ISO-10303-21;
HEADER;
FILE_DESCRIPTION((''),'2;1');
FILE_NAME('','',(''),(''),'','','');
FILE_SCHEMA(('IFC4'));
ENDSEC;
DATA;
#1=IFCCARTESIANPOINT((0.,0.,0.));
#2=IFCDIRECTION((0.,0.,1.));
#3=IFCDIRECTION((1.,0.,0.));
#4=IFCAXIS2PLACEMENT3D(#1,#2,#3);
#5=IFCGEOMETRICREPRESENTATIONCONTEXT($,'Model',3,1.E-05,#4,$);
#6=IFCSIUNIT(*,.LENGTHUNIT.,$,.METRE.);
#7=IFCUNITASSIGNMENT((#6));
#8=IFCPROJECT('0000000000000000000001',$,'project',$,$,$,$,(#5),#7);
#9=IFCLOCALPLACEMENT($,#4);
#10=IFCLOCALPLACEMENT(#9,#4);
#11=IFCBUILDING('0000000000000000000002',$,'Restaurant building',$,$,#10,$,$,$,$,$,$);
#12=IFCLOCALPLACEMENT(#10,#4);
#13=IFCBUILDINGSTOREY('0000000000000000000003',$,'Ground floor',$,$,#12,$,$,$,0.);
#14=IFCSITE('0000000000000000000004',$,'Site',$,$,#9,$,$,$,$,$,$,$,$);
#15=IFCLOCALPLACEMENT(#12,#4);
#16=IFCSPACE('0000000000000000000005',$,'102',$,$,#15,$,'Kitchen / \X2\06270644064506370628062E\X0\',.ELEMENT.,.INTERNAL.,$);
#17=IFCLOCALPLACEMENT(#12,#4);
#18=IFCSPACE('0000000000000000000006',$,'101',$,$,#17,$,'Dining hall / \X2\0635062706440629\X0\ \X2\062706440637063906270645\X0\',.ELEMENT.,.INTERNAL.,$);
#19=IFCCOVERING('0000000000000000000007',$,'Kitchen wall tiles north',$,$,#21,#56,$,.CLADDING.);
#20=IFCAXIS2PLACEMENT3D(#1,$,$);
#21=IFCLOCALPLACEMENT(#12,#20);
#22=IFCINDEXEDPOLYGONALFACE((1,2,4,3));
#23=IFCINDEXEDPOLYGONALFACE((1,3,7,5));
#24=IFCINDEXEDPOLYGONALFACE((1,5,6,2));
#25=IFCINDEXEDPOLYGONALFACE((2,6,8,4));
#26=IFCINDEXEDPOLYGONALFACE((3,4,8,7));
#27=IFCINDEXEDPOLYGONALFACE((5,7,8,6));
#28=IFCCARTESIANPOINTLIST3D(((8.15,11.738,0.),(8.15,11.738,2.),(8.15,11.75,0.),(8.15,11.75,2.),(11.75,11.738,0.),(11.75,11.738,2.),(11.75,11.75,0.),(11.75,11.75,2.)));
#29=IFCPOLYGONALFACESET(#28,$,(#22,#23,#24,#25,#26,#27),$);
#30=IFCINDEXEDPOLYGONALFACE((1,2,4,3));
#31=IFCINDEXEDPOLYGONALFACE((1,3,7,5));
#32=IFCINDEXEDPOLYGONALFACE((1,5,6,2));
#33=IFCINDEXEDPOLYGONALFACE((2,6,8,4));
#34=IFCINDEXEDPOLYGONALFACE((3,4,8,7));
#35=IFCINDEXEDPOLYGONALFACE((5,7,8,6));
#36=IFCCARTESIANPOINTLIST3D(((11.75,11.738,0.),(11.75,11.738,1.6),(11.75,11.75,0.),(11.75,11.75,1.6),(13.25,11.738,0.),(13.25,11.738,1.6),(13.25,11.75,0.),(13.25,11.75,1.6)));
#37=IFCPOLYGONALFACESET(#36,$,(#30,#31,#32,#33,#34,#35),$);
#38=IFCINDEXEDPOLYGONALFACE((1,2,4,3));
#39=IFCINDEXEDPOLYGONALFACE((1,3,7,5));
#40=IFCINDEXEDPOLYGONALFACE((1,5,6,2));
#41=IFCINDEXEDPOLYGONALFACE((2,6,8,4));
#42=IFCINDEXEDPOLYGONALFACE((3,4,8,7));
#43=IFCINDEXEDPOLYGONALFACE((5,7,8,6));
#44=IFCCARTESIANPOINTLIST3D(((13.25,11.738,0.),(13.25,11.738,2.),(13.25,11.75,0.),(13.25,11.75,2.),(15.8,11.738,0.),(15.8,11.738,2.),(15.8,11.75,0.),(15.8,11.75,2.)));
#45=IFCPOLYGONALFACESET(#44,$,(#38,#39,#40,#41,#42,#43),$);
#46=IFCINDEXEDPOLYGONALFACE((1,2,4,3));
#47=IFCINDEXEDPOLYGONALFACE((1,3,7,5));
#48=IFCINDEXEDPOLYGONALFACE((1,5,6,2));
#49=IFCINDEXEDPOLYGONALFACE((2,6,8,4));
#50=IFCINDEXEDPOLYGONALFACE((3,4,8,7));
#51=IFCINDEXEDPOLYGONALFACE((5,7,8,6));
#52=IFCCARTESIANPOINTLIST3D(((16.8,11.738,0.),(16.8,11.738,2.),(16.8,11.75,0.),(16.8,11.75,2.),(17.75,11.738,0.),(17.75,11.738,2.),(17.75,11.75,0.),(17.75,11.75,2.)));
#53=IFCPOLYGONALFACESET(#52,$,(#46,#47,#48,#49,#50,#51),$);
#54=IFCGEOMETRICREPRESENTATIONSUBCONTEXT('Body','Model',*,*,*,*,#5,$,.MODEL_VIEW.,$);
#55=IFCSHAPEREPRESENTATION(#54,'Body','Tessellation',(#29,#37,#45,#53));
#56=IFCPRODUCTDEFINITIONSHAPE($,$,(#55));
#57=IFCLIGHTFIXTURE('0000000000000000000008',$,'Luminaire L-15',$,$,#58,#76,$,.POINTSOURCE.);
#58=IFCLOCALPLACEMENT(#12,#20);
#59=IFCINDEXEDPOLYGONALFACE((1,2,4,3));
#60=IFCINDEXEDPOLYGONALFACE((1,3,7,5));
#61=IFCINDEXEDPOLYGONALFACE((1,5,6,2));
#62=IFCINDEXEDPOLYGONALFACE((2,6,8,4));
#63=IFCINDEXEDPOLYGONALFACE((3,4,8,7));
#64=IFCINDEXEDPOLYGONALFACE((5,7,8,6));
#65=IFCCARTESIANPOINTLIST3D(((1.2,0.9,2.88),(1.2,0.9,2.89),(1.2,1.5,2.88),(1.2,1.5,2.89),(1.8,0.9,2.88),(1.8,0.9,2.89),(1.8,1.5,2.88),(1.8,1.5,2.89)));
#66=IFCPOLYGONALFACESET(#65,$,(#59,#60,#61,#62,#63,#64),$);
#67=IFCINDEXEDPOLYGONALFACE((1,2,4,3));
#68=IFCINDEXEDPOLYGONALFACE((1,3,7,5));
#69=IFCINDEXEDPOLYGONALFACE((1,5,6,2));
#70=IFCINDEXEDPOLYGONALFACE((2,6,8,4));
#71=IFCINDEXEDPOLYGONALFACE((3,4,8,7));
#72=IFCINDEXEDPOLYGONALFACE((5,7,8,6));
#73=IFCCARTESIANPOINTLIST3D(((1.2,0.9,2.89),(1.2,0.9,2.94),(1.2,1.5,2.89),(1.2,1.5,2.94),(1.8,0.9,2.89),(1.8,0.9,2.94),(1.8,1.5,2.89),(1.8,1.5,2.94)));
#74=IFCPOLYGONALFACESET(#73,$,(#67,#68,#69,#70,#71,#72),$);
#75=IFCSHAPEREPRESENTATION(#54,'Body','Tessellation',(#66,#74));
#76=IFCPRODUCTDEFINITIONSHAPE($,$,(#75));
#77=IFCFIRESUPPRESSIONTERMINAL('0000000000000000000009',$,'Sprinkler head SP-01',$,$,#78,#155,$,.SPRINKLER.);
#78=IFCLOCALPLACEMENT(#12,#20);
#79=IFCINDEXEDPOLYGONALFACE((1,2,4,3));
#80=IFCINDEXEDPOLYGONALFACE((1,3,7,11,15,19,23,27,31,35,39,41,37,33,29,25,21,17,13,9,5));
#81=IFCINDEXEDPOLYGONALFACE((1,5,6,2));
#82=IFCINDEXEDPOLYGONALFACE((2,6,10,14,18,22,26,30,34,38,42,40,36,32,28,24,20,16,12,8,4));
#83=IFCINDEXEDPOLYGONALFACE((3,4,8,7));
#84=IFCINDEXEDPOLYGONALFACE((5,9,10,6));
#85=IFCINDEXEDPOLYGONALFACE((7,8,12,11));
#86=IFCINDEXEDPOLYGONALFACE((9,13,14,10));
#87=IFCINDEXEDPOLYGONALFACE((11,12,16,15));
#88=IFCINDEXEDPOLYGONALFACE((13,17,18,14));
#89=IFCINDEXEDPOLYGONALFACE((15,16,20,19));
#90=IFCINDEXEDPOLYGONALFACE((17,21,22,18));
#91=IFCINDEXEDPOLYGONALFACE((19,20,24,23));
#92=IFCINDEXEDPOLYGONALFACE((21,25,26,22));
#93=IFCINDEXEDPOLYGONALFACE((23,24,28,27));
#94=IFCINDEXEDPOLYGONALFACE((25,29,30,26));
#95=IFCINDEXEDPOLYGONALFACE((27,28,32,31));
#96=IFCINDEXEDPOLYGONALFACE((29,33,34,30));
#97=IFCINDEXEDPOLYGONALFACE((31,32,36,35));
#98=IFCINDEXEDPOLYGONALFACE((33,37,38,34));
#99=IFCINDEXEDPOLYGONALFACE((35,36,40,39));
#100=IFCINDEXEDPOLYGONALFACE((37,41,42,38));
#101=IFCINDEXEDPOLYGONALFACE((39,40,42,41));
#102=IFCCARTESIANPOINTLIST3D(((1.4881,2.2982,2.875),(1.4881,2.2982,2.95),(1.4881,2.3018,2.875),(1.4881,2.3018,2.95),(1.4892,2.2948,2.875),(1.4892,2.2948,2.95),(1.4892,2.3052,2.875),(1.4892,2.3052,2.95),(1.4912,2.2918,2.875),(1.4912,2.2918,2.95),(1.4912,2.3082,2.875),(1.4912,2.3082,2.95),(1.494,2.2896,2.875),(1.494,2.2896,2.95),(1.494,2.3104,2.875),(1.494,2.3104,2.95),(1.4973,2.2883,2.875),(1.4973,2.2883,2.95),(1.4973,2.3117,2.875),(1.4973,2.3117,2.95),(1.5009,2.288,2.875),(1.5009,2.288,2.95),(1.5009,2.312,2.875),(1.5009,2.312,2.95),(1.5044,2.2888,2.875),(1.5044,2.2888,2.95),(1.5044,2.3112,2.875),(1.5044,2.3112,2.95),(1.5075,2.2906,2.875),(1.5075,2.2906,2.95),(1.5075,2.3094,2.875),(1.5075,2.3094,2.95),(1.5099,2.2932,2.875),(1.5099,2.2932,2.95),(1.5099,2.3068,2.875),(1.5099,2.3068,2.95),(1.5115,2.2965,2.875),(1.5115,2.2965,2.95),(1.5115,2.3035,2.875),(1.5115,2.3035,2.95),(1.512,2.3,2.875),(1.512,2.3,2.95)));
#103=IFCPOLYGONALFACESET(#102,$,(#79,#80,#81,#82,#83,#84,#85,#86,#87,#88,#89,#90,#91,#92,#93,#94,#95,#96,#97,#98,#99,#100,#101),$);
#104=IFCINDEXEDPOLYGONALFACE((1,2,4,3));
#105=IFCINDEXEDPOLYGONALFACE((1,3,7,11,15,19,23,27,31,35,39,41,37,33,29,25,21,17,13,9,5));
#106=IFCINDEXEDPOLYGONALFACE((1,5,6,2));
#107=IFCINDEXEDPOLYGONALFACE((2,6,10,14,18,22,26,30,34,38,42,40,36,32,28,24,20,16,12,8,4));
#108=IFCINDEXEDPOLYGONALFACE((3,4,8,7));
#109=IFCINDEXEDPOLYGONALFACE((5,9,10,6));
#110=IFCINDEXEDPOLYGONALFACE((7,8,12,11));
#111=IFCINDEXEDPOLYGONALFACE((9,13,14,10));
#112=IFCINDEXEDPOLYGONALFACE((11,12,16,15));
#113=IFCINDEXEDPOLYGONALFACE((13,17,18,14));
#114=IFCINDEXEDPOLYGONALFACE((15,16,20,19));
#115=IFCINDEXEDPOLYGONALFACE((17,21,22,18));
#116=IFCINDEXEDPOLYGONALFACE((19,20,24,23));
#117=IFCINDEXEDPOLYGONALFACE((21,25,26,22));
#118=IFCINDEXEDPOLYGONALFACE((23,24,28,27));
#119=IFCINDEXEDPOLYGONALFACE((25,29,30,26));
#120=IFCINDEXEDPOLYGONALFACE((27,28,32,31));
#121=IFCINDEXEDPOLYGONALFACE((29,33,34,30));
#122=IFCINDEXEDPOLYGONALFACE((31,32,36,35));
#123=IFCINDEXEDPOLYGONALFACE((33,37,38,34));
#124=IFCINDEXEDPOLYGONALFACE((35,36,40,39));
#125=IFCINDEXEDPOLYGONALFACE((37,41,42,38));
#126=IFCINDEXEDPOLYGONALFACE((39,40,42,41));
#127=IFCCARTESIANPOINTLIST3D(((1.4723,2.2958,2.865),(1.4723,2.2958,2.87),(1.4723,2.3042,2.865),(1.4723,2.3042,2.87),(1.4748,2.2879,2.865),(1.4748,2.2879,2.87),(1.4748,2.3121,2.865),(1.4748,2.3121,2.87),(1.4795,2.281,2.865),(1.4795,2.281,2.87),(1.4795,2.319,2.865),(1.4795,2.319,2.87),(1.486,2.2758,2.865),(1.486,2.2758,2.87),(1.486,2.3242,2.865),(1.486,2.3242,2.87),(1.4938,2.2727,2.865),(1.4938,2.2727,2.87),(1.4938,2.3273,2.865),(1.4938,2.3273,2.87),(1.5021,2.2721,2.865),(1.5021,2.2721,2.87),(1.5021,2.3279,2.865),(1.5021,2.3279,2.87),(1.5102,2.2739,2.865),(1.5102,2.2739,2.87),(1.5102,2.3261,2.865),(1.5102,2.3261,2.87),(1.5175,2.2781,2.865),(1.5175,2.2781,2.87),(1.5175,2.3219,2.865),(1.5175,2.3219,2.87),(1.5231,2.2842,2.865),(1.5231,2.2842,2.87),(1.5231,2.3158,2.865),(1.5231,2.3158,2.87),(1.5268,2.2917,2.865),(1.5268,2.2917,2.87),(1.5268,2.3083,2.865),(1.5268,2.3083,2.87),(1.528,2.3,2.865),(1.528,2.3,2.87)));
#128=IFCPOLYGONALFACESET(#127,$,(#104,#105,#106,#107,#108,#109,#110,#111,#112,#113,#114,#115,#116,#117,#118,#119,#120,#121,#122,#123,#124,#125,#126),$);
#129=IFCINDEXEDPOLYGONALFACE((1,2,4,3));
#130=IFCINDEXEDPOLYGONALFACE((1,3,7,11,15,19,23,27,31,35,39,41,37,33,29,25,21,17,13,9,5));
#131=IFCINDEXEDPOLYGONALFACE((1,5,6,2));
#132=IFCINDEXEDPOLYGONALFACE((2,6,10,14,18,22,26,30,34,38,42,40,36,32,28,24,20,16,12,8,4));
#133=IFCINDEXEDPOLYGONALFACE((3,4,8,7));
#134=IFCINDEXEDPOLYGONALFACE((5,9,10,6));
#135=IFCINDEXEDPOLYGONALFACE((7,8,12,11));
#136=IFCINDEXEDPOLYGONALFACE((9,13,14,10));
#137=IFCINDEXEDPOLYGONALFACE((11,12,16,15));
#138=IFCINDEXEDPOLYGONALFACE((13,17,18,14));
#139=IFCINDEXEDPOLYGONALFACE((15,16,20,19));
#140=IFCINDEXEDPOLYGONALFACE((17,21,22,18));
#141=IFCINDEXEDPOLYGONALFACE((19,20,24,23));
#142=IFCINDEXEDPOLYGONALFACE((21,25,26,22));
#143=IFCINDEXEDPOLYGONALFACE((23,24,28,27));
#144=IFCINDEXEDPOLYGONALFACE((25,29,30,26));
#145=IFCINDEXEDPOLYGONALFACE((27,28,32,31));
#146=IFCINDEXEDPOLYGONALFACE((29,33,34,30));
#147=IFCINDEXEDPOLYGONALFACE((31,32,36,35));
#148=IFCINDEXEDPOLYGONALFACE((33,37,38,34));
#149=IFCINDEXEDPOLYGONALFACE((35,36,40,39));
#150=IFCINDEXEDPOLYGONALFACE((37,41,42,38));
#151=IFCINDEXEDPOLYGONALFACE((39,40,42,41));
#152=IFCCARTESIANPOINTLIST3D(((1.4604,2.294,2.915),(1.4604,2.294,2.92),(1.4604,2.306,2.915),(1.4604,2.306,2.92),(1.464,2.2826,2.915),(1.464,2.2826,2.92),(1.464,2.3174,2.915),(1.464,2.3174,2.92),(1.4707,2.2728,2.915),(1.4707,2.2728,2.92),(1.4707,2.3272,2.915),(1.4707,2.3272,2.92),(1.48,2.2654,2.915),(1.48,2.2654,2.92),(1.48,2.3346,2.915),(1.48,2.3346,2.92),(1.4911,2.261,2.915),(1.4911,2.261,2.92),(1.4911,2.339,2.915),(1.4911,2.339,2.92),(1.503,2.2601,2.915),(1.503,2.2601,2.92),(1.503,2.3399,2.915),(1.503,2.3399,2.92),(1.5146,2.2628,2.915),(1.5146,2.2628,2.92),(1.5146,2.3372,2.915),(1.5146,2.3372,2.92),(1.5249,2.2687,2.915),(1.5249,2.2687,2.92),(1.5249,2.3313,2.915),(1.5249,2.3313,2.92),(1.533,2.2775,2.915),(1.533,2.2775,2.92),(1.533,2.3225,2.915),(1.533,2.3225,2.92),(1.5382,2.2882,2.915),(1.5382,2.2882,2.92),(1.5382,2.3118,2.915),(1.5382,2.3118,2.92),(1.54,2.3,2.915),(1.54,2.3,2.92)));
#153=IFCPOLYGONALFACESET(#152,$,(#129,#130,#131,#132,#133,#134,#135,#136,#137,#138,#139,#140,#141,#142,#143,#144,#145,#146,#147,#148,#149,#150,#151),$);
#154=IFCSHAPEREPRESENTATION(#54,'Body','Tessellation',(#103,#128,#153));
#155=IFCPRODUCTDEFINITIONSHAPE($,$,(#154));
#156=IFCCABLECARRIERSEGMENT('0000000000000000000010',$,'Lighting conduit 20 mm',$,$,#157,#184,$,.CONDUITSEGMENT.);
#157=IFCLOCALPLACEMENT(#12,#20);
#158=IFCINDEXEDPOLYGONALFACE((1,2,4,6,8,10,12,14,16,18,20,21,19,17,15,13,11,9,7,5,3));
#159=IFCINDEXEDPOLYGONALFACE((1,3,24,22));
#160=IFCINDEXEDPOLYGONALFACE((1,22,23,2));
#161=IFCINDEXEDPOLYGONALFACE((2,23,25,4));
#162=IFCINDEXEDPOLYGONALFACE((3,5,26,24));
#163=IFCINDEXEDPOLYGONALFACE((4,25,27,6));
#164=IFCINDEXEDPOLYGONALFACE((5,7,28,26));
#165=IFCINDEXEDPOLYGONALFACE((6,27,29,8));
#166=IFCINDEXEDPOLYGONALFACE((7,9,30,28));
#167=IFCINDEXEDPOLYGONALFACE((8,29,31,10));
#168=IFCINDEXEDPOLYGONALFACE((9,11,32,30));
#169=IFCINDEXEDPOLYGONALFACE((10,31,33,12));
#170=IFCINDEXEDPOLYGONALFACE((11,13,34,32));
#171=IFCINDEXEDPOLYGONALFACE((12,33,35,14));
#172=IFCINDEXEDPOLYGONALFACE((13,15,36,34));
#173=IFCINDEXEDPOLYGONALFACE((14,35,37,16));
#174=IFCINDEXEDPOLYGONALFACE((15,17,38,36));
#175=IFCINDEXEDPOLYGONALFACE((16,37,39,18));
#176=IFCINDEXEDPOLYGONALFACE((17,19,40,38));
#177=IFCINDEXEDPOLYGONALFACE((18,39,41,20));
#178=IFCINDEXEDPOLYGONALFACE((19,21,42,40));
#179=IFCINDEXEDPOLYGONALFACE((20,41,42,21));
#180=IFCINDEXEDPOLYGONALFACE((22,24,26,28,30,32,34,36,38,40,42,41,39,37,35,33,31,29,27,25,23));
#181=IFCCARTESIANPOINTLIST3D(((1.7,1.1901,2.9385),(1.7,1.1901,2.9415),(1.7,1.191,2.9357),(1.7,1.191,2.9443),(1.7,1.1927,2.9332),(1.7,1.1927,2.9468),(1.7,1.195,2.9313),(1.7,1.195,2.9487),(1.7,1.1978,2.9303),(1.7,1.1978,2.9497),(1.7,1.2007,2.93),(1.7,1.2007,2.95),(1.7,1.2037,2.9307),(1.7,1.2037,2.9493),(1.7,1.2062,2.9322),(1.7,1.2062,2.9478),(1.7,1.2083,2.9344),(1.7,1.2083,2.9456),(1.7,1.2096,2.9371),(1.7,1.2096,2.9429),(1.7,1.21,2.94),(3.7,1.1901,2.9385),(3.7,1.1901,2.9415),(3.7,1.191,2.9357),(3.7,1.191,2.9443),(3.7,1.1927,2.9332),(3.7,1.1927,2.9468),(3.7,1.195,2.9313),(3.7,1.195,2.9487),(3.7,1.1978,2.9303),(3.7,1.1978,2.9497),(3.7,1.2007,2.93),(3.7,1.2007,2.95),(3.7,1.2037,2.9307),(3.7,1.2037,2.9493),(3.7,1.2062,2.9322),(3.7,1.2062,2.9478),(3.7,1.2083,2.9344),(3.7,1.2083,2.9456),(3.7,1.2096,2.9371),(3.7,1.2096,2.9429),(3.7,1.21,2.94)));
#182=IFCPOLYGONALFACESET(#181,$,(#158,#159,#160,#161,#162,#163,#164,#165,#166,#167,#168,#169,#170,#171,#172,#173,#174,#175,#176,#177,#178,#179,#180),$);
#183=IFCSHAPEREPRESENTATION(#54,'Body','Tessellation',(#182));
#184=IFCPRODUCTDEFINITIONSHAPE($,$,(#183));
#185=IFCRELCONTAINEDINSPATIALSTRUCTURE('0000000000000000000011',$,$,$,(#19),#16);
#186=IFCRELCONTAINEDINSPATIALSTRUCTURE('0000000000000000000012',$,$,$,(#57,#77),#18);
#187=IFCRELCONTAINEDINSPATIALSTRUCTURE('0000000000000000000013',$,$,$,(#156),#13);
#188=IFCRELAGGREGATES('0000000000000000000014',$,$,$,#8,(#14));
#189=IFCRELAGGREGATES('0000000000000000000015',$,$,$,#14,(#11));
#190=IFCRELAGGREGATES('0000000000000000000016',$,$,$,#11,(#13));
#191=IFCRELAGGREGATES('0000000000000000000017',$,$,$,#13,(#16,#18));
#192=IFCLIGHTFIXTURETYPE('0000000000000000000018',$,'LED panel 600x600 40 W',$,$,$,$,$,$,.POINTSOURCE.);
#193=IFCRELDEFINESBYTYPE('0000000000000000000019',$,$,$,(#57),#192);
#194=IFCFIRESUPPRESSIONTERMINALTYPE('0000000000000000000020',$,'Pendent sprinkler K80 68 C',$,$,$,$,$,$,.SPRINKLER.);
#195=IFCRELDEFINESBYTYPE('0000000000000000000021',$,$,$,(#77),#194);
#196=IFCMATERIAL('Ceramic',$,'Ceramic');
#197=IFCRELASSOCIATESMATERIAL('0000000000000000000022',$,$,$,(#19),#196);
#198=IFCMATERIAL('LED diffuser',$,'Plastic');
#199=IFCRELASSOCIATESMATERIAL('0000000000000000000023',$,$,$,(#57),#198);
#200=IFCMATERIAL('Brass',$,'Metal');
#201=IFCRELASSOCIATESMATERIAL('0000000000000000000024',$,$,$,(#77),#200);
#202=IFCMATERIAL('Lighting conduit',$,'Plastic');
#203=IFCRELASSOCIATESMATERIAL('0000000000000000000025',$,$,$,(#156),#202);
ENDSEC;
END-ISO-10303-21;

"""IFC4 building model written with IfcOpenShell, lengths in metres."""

from ifc_helpers import new_model, si_unit, frame, origin, origin_with_axes, origin_2d, place, context, subcontext, project, spatial, rectangle, circle, extrude, source, transform, mapped, material, type_object, type_shapes, element, save


model = new_model("IFC4")

# Units and contexts
model_context = context("Model", 3, precision=1e-05, world=origin_with_axes())
body_context = subcontext(model_context, "Body", "Model", "MODEL_VIEW")
ifc_project = project(units=[si_unit("LENGTHUNIT", "METRE")], contexts=[model_context])

# Site, building, storey
site_placement = place(None, origin_with_axes())
site = spatial("IfcSite", under=ifc_project, at=site_placement, Name="Site")
building_placement = place(site_placement, origin_with_axes())
building = spatial("IfcBuilding", under=site, at=building_placement, Name="Restaurant building")
storey_placement = place(building_placement, origin_with_axes())
storey = spatial("IfcBuildingStorey", under=building, at=storey_placement, Name="Ground floor", Elevation=0.0)

# Shared definitions
space_1_placement = place(storey_placement, origin_with_axes())
space_1 = spatial("IfcSpace", under=storey, at=space_1_placement, Name="102", LongName="Kitchen / المطبخ", CompositionType="ELEMENT", PredefinedType="INTERNAL")

# Covering
ifc_material_1 = material(Name="Ceramic", Category="Ceramic")
covering_1_placement = place(storey_placement, origin())
element("IfcCovering", 1, at=covering_1_placement, inside=space_1, material=ifc_material_1, Name="Kitchen wall tiles north", PredefinedType="CLADDING", context=body_context, shape_type="SweptSolid", body=[
    extrude(rectangle(XDim=3.6, YDim=0.012, at=origin_2d()), frame((9.95, 11.744, 0.0)), (0.0, 0.0, 1.0), 2.0),
    extrude(rectangle(XDim=1.5, YDim=0.012, at=origin_2d()), frame((12.5, 11.744, 0.0)), (0.0, 0.0, 1.0), 1.6),
    extrude(rectangle(XDim=2.55, YDim=0.012, at=origin_2d()), frame((14.525, 11.744, 0.0)), (0.0, 0.0, 1.0), 2.0),
    extrude(rectangle(XDim=0.95, YDim=0.012, at=origin_2d()), frame((17.275, 11.744, 0.0)), (0.0, 0.0, 1.0), 2.0),
])

# Shared definitions
space_2_placement = place(storey_placement, origin_with_axes())
space_2 = spatial("IfcSpace", under=storey, at=space_2_placement, Name="101", LongName="Dining hall / صالة الطعام", CompositionType="ELEMENT", PredefinedType="INTERNAL")

# Light fixture
ifc_material_2 = material(Name="LED diffuser", Category="Plastic")
light_fixture_type = type_object("IfcLightFixtureType", Name="LED panel 600x600 40 W", PredefinedType="POINTSOURCE")
shared_shape_1 = source(origin(), body_context, "Body", "SweptSolid", [
    extrude(rectangle(XDim=0.6, YDim=0.6, at=origin_2d()), frame((0.0, 0.0, -0.06)), (0.0, 0.0, 1.0), 0.01),
    extrude(rectangle(XDim=0.6, YDim=0.6, at=origin_2d()), frame((0.0, 0.0, -0.05)), (0.0, 0.0, 1.0), 0.05),
])
type_shapes(light_fixture_type, [shared_shape_1])
light_fixture_placement = place(storey_placement, frame((1.5, 1.2, 2.94)))
element("IfcLightFixture", 2, at=light_fixture_placement, inside=space_2, type_object=light_fixture_type, material=ifc_material_2, Name="Luminaire L-15", PredefinedType="POINTSOURCE", context=body_context, shape_type="MappedRepresentation", body=[
    mapped(shared_shape_1, transform((0.0, 0.0, 0.0))),
])

# Fire suppression terminal
ifc_material_3 = material(Name="Brass", Category="Metal")
fire_suppression_terminal_type = type_object("IfcFireSuppressionTerminalType", Name="Pendent sprinkler K80 68 C", PredefinedType="SPRINKLER")
shared_shape_2 = source(origin(), body_context, "Body", "SweptSolid", [
    extrude(circle(Radius=0.012, at=origin_2d()), frame((0.0, 0.0, -0.075)), (0.0, 0.0, 1.0), 0.075),
    extrude(circle(Radius=0.028, at=origin_2d()), frame((0.0, 0.0, -0.085)), (0.0, 0.0, 1.0), 0.005),
    extrude(circle(Radius=0.04, at=origin_2d()), frame((0.0, 0.0, -0.035)), (0.0, 0.0, 1.0), 0.005),
])
type_shapes(fire_suppression_terminal_type, [shared_shape_2])
fire_suppression_terminal_placement = place(storey_placement, frame((1.5, 2.3, 2.95)))
element("IfcFireSuppressionTerminal", 3, at=fire_suppression_terminal_placement, inside=space_2, type_object=fire_suppression_terminal_type, material=ifc_material_3, Name="Sprinkler head SP-01", PredefinedType="SPRINKLER", context=body_context, shape_type="MappedRepresentation", body=[
    mapped(shared_shape_2, transform((0.0, 0.0, 0.0))),
])

# Cable carrier segment
ifc_material_4 = material(Name="Lighting conduit", Category="Plastic")
cable_carrier_segment_1_placement = place(storey_placement, frame((1.7, 1.2, 2.94)))
element("IfcCableCarrierSegment", 4, at=cable_carrier_segment_1_placement, inside=storey, material=ifc_material_4, Name="Lighting conduit 20 mm", PredefinedType="CONDUITSEGMENT", context=body_context, shape_type="SweptSolid", body=[
    extrude(circle(Radius=0.01, at=origin_2d()), frame((0.0, 0.0, 0.0), z_axis=(1.0, 0.0, 0.0), x_axis=(0.0, 1.0, 0.0)), (0.0, 0.0, 1.0), 2.0),
])

save(model, "model.ifc")
